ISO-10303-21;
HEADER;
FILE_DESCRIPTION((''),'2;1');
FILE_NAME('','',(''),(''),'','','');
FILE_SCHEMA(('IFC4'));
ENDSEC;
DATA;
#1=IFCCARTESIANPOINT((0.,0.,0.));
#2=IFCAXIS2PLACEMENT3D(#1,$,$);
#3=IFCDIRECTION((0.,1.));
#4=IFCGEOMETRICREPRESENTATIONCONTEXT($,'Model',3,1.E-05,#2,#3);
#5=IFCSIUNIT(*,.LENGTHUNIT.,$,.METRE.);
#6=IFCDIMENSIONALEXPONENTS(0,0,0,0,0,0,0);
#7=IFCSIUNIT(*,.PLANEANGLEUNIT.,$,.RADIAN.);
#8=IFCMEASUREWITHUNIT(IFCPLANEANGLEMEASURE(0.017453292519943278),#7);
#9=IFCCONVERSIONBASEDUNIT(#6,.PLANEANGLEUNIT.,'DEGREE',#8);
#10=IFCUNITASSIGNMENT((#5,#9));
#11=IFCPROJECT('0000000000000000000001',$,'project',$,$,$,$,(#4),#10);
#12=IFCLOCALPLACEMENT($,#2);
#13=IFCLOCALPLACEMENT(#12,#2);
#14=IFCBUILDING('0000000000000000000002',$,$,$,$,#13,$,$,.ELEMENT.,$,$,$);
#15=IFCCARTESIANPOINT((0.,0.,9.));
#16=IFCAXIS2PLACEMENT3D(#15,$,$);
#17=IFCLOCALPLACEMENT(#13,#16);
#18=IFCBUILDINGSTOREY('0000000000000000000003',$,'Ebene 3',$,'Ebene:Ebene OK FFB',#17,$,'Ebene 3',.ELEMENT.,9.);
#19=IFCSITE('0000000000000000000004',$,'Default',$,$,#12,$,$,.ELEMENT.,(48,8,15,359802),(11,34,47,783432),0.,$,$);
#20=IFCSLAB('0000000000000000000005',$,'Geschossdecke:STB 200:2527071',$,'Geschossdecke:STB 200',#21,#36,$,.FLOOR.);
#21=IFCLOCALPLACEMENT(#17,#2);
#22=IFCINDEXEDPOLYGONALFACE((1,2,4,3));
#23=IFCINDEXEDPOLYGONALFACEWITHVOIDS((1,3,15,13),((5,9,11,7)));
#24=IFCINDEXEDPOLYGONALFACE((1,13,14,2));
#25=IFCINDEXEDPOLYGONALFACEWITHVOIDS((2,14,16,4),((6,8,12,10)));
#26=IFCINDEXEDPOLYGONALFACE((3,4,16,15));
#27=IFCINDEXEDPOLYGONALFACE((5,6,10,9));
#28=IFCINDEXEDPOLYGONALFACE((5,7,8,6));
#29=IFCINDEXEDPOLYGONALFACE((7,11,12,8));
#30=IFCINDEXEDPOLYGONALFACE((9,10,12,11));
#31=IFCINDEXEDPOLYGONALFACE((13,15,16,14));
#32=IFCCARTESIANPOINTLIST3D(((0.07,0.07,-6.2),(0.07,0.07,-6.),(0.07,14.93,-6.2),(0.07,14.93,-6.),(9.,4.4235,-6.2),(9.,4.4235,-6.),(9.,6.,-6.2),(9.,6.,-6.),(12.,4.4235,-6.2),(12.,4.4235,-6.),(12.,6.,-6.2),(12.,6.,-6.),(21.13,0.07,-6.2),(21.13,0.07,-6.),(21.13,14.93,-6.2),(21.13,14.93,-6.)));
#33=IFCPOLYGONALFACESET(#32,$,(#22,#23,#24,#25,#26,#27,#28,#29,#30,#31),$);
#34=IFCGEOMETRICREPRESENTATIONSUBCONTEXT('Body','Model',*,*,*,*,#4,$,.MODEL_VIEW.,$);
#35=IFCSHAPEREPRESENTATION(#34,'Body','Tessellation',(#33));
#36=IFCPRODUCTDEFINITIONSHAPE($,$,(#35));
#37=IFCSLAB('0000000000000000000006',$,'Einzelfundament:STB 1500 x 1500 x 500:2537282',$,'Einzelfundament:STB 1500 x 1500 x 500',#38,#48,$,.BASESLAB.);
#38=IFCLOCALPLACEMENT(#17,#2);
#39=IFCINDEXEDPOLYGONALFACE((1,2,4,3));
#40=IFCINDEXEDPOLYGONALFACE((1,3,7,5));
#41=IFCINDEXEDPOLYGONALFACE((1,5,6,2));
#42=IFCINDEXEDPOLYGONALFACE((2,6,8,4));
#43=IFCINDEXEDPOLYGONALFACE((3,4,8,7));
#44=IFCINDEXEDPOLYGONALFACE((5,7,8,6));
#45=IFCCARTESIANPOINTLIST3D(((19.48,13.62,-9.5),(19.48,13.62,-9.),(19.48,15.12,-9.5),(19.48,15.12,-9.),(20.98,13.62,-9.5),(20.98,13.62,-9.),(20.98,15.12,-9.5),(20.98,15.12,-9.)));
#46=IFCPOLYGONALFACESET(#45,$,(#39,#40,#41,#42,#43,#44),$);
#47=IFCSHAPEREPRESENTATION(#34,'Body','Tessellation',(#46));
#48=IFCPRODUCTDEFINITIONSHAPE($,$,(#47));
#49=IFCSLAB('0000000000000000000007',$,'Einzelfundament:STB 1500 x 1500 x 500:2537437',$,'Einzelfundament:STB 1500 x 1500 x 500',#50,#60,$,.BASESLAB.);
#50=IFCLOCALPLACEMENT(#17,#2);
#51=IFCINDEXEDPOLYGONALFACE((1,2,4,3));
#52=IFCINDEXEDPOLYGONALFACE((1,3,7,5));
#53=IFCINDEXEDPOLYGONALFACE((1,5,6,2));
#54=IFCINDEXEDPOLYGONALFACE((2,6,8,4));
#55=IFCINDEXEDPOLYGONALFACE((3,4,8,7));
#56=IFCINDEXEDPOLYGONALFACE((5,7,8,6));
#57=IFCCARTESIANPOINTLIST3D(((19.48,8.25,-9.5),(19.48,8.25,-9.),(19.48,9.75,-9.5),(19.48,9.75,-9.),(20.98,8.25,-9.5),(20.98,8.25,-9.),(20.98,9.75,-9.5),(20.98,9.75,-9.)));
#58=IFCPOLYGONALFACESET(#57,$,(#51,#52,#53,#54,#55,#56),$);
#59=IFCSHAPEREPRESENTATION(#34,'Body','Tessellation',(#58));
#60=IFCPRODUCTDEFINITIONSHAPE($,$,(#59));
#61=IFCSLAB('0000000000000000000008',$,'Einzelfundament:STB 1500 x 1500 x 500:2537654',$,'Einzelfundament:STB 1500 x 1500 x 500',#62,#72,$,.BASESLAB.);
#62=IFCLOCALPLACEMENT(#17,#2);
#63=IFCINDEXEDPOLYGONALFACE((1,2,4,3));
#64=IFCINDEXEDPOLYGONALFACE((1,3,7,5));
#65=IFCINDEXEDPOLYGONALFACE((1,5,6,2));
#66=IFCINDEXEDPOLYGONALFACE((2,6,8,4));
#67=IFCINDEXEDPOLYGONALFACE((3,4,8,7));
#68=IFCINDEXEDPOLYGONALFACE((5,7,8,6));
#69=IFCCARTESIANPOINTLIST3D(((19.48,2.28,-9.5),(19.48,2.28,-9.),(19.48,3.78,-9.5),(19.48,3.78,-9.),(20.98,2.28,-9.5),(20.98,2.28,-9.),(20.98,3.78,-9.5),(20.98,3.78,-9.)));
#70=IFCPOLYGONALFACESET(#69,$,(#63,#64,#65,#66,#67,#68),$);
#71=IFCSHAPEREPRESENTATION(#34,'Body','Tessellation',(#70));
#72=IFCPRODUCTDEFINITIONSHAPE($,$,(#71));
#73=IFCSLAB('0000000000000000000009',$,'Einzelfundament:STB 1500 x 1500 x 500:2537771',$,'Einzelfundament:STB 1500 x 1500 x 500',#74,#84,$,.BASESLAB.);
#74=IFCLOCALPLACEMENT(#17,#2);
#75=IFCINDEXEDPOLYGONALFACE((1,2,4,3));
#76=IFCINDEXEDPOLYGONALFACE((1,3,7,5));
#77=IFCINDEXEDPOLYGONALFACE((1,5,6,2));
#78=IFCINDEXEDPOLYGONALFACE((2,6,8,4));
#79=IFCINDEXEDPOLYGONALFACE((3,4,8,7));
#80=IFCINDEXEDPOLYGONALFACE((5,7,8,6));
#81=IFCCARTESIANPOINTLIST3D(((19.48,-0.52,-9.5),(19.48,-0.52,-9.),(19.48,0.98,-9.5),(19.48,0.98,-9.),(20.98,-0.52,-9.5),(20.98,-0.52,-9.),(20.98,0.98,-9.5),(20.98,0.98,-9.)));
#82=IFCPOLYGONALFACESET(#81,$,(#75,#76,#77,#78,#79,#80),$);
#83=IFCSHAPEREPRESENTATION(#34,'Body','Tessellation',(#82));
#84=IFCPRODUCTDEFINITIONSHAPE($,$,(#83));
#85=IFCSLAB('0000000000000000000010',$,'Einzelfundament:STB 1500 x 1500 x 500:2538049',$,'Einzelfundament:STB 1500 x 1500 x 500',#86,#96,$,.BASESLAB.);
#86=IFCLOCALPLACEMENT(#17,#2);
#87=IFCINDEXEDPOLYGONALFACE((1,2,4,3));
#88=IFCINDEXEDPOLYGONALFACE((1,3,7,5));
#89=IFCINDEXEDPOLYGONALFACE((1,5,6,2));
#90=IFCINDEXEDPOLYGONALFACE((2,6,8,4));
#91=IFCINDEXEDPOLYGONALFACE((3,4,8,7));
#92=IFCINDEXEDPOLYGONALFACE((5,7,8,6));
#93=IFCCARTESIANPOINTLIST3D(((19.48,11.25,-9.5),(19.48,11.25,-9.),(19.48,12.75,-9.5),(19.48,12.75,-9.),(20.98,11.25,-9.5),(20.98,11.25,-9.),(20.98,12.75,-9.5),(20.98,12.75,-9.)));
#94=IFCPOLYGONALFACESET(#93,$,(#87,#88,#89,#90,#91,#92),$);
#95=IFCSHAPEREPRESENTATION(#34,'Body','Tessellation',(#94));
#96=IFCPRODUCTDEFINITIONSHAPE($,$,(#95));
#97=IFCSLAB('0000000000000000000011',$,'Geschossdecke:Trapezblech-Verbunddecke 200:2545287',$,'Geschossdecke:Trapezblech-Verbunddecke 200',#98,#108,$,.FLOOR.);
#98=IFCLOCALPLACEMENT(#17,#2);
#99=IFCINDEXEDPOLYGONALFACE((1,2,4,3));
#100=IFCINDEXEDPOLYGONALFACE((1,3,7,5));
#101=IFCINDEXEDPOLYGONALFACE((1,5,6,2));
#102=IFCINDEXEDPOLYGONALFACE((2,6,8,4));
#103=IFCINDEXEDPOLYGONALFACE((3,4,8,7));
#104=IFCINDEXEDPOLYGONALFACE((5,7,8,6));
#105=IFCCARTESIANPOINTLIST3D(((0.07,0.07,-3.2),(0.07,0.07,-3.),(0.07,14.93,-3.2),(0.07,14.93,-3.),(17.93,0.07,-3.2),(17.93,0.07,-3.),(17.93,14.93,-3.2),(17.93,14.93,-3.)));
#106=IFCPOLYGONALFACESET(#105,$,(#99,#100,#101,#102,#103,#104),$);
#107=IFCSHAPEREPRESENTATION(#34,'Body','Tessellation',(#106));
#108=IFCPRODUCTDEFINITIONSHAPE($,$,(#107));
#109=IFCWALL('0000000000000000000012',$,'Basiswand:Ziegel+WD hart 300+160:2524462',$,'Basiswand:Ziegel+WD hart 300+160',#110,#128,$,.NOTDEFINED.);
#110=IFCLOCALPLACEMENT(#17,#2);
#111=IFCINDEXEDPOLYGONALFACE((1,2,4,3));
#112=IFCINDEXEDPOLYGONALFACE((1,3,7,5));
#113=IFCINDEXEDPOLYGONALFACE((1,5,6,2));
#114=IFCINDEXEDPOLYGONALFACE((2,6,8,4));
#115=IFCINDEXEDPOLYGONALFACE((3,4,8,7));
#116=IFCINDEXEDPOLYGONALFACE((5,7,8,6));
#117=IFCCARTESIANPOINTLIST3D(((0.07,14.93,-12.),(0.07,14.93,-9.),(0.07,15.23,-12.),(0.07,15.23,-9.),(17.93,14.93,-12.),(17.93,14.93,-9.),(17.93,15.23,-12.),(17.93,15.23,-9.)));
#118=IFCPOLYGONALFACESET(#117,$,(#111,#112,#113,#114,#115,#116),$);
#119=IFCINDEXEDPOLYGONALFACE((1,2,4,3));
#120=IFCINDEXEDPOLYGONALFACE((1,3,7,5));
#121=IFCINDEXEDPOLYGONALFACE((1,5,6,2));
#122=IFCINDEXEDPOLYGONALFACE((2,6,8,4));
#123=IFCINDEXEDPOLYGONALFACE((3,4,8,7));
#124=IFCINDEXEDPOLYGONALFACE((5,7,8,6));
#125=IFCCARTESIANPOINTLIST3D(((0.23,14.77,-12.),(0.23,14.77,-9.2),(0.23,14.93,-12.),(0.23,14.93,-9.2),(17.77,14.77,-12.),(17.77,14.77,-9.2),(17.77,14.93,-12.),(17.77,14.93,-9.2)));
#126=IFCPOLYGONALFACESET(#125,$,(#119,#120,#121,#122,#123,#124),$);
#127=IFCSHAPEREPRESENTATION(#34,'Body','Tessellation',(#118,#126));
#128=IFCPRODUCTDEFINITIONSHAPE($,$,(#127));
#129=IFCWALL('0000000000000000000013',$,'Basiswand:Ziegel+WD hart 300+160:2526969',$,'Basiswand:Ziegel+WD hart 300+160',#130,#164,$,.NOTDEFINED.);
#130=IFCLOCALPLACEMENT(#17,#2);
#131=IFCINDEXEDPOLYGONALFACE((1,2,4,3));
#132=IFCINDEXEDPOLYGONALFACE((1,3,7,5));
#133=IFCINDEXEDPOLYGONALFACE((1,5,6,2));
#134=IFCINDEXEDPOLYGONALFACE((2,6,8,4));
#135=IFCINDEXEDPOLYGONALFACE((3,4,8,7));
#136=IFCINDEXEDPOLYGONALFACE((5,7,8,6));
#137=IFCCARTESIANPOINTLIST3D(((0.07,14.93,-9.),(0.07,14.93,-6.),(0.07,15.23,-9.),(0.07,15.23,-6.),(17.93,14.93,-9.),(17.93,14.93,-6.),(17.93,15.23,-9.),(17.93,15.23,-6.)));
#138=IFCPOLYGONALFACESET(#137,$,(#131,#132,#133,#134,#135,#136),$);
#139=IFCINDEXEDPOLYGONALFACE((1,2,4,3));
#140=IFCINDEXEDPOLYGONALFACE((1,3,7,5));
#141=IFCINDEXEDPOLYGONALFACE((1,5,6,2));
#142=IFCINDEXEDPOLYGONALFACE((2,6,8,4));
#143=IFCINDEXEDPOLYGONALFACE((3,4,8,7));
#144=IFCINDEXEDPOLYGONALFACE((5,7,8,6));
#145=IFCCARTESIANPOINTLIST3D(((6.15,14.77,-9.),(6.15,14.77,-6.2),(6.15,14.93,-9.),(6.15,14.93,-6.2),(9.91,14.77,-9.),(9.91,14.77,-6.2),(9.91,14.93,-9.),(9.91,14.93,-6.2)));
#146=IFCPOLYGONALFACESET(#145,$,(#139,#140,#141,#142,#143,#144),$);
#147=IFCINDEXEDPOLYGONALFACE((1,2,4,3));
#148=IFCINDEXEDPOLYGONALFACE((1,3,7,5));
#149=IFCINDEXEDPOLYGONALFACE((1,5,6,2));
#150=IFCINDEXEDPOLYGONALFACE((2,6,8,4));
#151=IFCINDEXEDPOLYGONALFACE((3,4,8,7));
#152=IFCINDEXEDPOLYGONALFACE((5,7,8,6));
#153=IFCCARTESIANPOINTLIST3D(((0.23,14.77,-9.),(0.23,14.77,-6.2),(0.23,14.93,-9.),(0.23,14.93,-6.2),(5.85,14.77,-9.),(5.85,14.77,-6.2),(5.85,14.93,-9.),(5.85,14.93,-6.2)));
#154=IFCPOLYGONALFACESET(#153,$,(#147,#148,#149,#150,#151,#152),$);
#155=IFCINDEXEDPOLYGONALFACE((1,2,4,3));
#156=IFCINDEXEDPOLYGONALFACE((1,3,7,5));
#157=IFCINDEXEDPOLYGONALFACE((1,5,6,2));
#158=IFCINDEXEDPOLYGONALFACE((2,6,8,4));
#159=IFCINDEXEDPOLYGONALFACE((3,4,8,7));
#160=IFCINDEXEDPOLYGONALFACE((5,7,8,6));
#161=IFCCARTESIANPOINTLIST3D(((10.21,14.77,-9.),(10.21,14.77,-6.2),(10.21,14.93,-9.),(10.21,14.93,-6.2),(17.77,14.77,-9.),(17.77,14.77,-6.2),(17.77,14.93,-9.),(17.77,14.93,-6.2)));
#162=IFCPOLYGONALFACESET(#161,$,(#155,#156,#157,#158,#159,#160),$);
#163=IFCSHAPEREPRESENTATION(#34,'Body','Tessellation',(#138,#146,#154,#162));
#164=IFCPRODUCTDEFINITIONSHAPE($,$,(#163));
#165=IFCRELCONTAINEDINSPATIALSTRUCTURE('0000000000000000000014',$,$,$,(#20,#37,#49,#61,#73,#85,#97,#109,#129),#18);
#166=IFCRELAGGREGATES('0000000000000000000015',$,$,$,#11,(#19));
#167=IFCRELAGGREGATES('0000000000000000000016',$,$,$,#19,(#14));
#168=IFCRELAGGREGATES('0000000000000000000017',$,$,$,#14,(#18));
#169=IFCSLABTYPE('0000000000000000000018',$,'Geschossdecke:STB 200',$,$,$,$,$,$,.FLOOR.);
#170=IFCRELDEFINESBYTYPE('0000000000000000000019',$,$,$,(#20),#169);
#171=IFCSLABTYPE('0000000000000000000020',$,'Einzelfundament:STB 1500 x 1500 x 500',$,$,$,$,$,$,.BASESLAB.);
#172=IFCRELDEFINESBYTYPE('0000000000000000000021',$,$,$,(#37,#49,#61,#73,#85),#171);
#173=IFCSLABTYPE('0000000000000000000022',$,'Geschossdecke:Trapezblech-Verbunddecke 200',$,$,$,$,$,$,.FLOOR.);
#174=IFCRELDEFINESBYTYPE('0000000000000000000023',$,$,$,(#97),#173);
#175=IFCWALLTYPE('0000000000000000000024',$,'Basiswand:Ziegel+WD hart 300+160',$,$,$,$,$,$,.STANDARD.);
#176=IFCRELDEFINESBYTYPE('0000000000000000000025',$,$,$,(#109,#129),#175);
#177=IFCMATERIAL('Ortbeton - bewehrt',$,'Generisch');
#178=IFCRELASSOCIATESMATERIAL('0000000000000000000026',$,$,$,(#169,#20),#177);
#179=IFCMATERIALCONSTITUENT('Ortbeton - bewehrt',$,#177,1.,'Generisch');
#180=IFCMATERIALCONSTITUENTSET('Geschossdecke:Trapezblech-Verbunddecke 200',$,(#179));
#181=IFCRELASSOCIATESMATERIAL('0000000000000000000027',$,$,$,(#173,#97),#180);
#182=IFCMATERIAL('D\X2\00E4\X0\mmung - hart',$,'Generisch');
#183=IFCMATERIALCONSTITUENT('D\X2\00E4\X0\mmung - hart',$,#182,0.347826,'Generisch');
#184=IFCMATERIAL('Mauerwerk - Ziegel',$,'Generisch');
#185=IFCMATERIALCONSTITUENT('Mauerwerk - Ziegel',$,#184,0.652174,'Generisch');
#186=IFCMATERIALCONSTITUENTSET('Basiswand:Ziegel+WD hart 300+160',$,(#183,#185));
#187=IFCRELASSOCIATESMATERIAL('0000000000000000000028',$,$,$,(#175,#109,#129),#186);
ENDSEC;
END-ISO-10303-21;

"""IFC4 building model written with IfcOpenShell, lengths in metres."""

from ifc_helpers import new_model, entity, si_unit, converted_unit, direction, frame, origin, place, context, subcontext, project, spatial, indexed_curve, outline, extrude, material, constituent, constituent_set, type_object, element, save


model = new_model("IFC4")

# Units and contexts
model_context = context("Model", 3, precision=1e-05, world=origin(), true_north=direction((0.0, 1.0)))
body_context = subcontext(model_context, "Body", "Model", "MODEL_VIEW")
ifc_project = project(units=[si_unit("LENGTHUNIT", "METRE"), converted_unit("PLANEANGLEUNIT", "DEGREE", entity("IfcPlaneAngleMeasure", 0.017453292519943278), si_unit("PLANEANGLEUNIT", "RADIAN"), dimensions=[0, 0, 0, 0, 0, 0, 0])], contexts=[model_context])

# Site, building, storey
site_placement = place(None, origin())
site = spatial("IfcSite", under=ifc_project, at=site_placement, Name="Default", CompositionType="ELEMENT", RefLatitude=(48, 8, 15, 359802), RefLongitude=(11, 34, 47, 783432), RefElevation=0.0)
building_placement = place(site_placement, origin())
building = spatial("IfcBuilding", under=site, at=building_placement, CompositionType="ELEMENT")
storey_placement = place(building_placement, frame((0.0, 0.0, 9.0)))
storey = spatial("IfcBuildingStorey", under=building, at=storey_placement, Name="Ebene 3", ObjectType="Ebene:Ebene OK FFB", LongName="Ebene 3", CompositionType="ELEMENT", Elevation=9.0)

# Shared definitions
ifc_material_1 = material(Name="Ortbeton - bewehrt", Category="Generisch")
slab_type_1 = type_object("IfcSlabType", Name="Geschossdecke:STB 200", PredefinedType="FLOOR", material=ifc_material_1)

# Slab, opening
slab_1_placement = place(storey_placement, origin())
slab_1 = element("IfcSlab", 1, at=slab_1_placement, inside=storey, type_object=slab_type_1, material=ifc_material_1, Name="Geschossdecke:STB 200:2527071", ObjectType="Geschossdecke:STB 200", PredefinedType="FLOOR", context=body_context, shape_type="SweptSolid", body=[
    extrude(outline(indexed_curve([(-10.53, -7.43), (10.53, -7.43), (10.53, 7.43), (-10.53, 7.43), (-10.53, -7.43)], self_intersect=False), holes=[indexed_curve([(1.4, -1.5), (1.4, -3.0765), (-1.6, -3.0765), (-1.6, -1.5), (1.4, -1.5)], self_intersect=False)]), frame((10.6, 7.5, -6.2)), (0.0, 0.0, 1.0), 0.2),
])
opening_1_placement = place(slab_1_placement, origin())
element("IfcOpeningElement", 2, at=opening_1_placement, cuts=slab_1, PredefinedType="OPENING", context=body_context, shape_type="SweptSolid", body=[
    extrude(outline(indexed_curve([(12.0, 6.0), (9.0, 6.0), (9.0, 4.4235), (12.0, 4.4235), (12.0, 6.0)], self_intersect=False)), frame((0.0, 0.0, -9.0)), (0.0, 0.0, -1.0), 14.86),
])

# Slabs
slab_type_2 = type_object("IfcSlabType", Name="Einzelfundament:STB 1500 x 1500 x 500", PredefinedType="BASESLAB")
slab_2_placement = place(storey_placement, origin())
element("IfcSlab", 3, at=slab_2_placement, inside=storey, type_object=slab_type_2, Name="Einzelfundament:STB 1500 x 1500 x 500:2537282", ObjectType="Einzelfundament:STB 1500 x 1500 x 500", PredefinedType="BASESLAB", context=body_context, shape_type="SweptSolid", body=[
    extrude(outline(indexed_curve([(-0.75, -0.75), (0.75, -0.75), (0.75, 0.75), (-0.75, 0.75), (-0.75, -0.75)], self_intersect=False)), frame((20.23, 14.37, -9.5), z_axis=(0.0, 0.0, 1.0), x_axis=(-1.0, 0.0, 0.0)), (0.0, 0.0, 1.0), 0.5),
])
slab_3_placement = place(storey_placement, origin())
element("IfcSlab", 4, at=slab_3_placement, inside=storey, type_object=slab_type_2, Name="Einzelfundament:STB 1500 x 1500 x 500:2537437", ObjectType="Einzelfundament:STB 1500 x 1500 x 500", PredefinedType="BASESLAB", context=body_context, shape_type="SweptSolid", body=[
    extrude(outline(indexed_curve([(-0.75, -0.75), (0.75, -0.75), (0.75, 0.75), (-0.75, 0.75), (-0.75, -0.75)], self_intersect=False)), frame((20.23, 9.0, -9.5), z_axis=(0.0, 0.0, 1.0), x_axis=(-1.0, 0.0, 0.0)), (0.0, 0.0, 1.0), 0.5),
])
slab_4_placement = place(storey_placement, origin())
element("IfcSlab", 5, at=slab_4_placement, inside=storey, type_object=slab_type_2, Name="Einzelfundament:STB 1500 x 1500 x 500:2537654", ObjectType="Einzelfundament:STB 1500 x 1500 x 500", PredefinedType="BASESLAB", context=body_context, shape_type="SweptSolid", body=[
    extrude(outline(indexed_curve([(-0.75, -0.75), (0.75, -0.75), (0.75, 0.75), (-0.75, 0.75), (-0.75, -0.75)], self_intersect=False)), frame((20.23, 3.03, -9.5), z_axis=(0.0, 0.0, 1.0), x_axis=(-1.0, 0.0, 0.0)), (0.0, 0.0, 1.0), 0.5),
])
slab_5_placement = place(storey_placement, origin())
element("IfcSlab", 6, at=slab_5_placement, inside=storey, type_object=slab_type_2, Name="Einzelfundament:STB 1500 x 1500 x 500:2537771", ObjectType="Einzelfundament:STB 1500 x 1500 x 500", PredefinedType="BASESLAB", context=body_context, shape_type="SweptSolid", body=[
    extrude(outline(indexed_curve([(-0.75, -0.75), (0.75, -0.75), (0.75, 0.75), (-0.75, 0.75), (-0.75, -0.75)], self_intersect=False)), frame((20.23, 0.23, -9.5), z_axis=(0.0, 0.0, 1.0), x_axis=(-1.0, 0.0, 0.0)), (0.0, 0.0, 1.0), 0.5),
])
slab_6_placement = place(storey_placement, origin())
element("IfcSlab", 7, at=slab_6_placement, inside=storey, type_object=slab_type_2, Name="Einzelfundament:STB 1500 x 1500 x 500:2538049", ObjectType="Einzelfundament:STB 1500 x 1500 x 500", PredefinedType="BASESLAB", context=body_context, shape_type="SweptSolid", body=[
    extrude(outline(indexed_curve([(-0.75, -0.75), (0.75, -0.75), (0.75, 0.75), (-0.75, 0.75), (-0.75, -0.75)], self_intersect=False)), frame((20.23, 12.0, -9.5), z_axis=(0.0, 0.0, 1.0), x_axis=(-1.0, 0.0, 0.0)), (0.0, 0.0, 1.0), 0.5),
])
ifc_constituent_1 = constituent(ifc_material_1, Name="Ortbeton - bewehrt", Category="Generisch", fraction=1.0)
ifc_constituent_set_1 = constituent_set(constituents=[ifc_constituent_1], Name="Geschossdecke:Trapezblech-Verbunddecke 200")
slab_type_3 = type_object("IfcSlabType", Name="Geschossdecke:Trapezblech-Verbunddecke 200", PredefinedType="FLOOR", material=ifc_constituent_set_1)
slab_7_placement = place(storey_placement, origin())
element("IfcSlab", 8, at=slab_7_placement, inside=storey, type_object=slab_type_3, material=ifc_constituent_set_1, Name="Geschossdecke:Trapezblech-Verbunddecke 200:2545287", ObjectType="Geschossdecke:Trapezblech-Verbunddecke 200", PredefinedType="FLOOR", context=body_context, shape_type="SweptSolid", body=[
    extrude(outline(indexed_curve([(-7.43, -8.93), (7.43, -8.93), (7.43, 8.93), (-7.43, 8.93), (-7.43, -8.93)], self_intersect=False)), frame((9.0, 7.5, -3.0), z_axis=(0.0, 0.0, -1.0), x_axis=(0.0, 1.0, 0.0)), (0.0, 0.0, 1.0), 0.2),
])

# Walls
ifc_material_2 = material(Name="Dämmung - hart", Category="Generisch")
ifc_constituent_2 = constituent(ifc_material_2, Name="Dämmung - hart", Category="Generisch", fraction=0.347826)
ifc_material_3 = material(Name="Mauerwerk - Ziegel", Category="Generisch")
ifc_constituent_3 = constituent(ifc_material_3, Name="Mauerwerk - Ziegel", Category="Generisch", fraction=0.652174)
ifc_constituent_set_2 = constituent_set(constituents=[ifc_constituent_2, ifc_constituent_3], Name="Basiswand:Ziegel+WD hart 300+160")
wall_type_1 = type_object("IfcWallType", Name="Basiswand:Ziegel+WD hart 300+160", PredefinedType="STANDARD", material=ifc_constituent_set_2)
wall_1_placement = place(storey_placement, frame((17.77, 15.0, -12.0), z_axis=(0.0, 0.0, 1.0), x_axis=(-1.0, 0.0, 0.0)))
element("IfcWall", 9, at=wall_1_placement, inside=storey, type_object=wall_type_1, material=ifc_constituent_set_2, Name="Basiswand:Ziegel+WD hart 300+160:2524462", ObjectType="Basiswand:Ziegel+WD hart 300+160", PredefinedType="NOTDEFINED", context=body_context, shape_type="SweptSolid", body=[
    extrude(outline(indexed_curve([(-0.15, -8.93), (0.15, -8.93), (0.15, 8.93), (-0.15, 8.93), (-0.15, -8.93)], self_intersect=False)), frame((8.77, -0.08, 0.0), z_axis=(0.0, 0.0, 1.0), x_axis=(0.0, 1.0, 0.0)), (0.0, 0.0, 1.0), 3.0),
    extrude(outline(indexed_curve([(-0.08, -8.77), (0.08, -8.77), (0.08, 8.77), (-0.08, 8.77), (-0.08, -8.77)], self_intersect=False)), frame((8.77, 0.15, 0.0), z_axis=(0.0, 0.0, 1.0), x_axis=(0.0, -1.0, 0.0)), (0.0, 0.0, 1.0), 2.8),
])
wall_2_placement = place(storey_placement, frame((17.77, 15.0, -9.0), z_axis=(0.0, 0.0, 1.0), x_axis=(-1.0, 0.0, 0.0)))
element("IfcWall", 10, at=wall_2_placement, inside=storey, type_object=wall_type_1, material=ifc_constituent_set_2, Name="Basiswand:Ziegel+WD hart 300+160:2526969", ObjectType="Basiswand:Ziegel+WD hart 300+160", PredefinedType="NOTDEFINED", context=body_context, shape_type="SweptSolid", body=[
    extrude(outline(indexed_curve([(-0.15, -8.93), (0.15, -8.93), (0.15, 8.93), (-0.15, 8.93), (-0.15, -8.93)], self_intersect=False)), frame((8.77, -0.08, 0.0), z_axis=(0.0, 0.0, 1.0), x_axis=(0.0, 1.0, 0.0)), (0.0, 0.0, 1.0), 3.0),
    extrude(outline(indexed_curve([(-1.88, -0.08), (1.88, -0.08), (1.88, 0.08), (-1.88, 0.08), (-1.88, -0.08)], self_intersect=False)), frame((9.74, 0.15, 0.0)), (0.0, 0.0, 1.0), 2.8),
    extrude(outline(indexed_curve([(-2.81, -0.08), (2.81, -0.08), (2.81, 0.08), (-2.81, 0.08), (-2.81, -0.08)], self_intersect=False)), frame((14.73, 0.15, 0.0), z_axis=(0.0, 0.0, 1.0), x_axis=(-1.0, 0.0, 0.0)), (0.0, 0.0, 1.0), 2.8),
    extrude(outline(indexed_curve([(-3.78, -0.08), (3.78, -0.08), (3.78, 0.08), (-3.78, 0.08), (-3.78, -0.08)], self_intersect=False)), frame((3.78, 0.15, 0.0)), (0.0, 0.0, 1.0), 2.8),
])

save(model, "model.ifc")
